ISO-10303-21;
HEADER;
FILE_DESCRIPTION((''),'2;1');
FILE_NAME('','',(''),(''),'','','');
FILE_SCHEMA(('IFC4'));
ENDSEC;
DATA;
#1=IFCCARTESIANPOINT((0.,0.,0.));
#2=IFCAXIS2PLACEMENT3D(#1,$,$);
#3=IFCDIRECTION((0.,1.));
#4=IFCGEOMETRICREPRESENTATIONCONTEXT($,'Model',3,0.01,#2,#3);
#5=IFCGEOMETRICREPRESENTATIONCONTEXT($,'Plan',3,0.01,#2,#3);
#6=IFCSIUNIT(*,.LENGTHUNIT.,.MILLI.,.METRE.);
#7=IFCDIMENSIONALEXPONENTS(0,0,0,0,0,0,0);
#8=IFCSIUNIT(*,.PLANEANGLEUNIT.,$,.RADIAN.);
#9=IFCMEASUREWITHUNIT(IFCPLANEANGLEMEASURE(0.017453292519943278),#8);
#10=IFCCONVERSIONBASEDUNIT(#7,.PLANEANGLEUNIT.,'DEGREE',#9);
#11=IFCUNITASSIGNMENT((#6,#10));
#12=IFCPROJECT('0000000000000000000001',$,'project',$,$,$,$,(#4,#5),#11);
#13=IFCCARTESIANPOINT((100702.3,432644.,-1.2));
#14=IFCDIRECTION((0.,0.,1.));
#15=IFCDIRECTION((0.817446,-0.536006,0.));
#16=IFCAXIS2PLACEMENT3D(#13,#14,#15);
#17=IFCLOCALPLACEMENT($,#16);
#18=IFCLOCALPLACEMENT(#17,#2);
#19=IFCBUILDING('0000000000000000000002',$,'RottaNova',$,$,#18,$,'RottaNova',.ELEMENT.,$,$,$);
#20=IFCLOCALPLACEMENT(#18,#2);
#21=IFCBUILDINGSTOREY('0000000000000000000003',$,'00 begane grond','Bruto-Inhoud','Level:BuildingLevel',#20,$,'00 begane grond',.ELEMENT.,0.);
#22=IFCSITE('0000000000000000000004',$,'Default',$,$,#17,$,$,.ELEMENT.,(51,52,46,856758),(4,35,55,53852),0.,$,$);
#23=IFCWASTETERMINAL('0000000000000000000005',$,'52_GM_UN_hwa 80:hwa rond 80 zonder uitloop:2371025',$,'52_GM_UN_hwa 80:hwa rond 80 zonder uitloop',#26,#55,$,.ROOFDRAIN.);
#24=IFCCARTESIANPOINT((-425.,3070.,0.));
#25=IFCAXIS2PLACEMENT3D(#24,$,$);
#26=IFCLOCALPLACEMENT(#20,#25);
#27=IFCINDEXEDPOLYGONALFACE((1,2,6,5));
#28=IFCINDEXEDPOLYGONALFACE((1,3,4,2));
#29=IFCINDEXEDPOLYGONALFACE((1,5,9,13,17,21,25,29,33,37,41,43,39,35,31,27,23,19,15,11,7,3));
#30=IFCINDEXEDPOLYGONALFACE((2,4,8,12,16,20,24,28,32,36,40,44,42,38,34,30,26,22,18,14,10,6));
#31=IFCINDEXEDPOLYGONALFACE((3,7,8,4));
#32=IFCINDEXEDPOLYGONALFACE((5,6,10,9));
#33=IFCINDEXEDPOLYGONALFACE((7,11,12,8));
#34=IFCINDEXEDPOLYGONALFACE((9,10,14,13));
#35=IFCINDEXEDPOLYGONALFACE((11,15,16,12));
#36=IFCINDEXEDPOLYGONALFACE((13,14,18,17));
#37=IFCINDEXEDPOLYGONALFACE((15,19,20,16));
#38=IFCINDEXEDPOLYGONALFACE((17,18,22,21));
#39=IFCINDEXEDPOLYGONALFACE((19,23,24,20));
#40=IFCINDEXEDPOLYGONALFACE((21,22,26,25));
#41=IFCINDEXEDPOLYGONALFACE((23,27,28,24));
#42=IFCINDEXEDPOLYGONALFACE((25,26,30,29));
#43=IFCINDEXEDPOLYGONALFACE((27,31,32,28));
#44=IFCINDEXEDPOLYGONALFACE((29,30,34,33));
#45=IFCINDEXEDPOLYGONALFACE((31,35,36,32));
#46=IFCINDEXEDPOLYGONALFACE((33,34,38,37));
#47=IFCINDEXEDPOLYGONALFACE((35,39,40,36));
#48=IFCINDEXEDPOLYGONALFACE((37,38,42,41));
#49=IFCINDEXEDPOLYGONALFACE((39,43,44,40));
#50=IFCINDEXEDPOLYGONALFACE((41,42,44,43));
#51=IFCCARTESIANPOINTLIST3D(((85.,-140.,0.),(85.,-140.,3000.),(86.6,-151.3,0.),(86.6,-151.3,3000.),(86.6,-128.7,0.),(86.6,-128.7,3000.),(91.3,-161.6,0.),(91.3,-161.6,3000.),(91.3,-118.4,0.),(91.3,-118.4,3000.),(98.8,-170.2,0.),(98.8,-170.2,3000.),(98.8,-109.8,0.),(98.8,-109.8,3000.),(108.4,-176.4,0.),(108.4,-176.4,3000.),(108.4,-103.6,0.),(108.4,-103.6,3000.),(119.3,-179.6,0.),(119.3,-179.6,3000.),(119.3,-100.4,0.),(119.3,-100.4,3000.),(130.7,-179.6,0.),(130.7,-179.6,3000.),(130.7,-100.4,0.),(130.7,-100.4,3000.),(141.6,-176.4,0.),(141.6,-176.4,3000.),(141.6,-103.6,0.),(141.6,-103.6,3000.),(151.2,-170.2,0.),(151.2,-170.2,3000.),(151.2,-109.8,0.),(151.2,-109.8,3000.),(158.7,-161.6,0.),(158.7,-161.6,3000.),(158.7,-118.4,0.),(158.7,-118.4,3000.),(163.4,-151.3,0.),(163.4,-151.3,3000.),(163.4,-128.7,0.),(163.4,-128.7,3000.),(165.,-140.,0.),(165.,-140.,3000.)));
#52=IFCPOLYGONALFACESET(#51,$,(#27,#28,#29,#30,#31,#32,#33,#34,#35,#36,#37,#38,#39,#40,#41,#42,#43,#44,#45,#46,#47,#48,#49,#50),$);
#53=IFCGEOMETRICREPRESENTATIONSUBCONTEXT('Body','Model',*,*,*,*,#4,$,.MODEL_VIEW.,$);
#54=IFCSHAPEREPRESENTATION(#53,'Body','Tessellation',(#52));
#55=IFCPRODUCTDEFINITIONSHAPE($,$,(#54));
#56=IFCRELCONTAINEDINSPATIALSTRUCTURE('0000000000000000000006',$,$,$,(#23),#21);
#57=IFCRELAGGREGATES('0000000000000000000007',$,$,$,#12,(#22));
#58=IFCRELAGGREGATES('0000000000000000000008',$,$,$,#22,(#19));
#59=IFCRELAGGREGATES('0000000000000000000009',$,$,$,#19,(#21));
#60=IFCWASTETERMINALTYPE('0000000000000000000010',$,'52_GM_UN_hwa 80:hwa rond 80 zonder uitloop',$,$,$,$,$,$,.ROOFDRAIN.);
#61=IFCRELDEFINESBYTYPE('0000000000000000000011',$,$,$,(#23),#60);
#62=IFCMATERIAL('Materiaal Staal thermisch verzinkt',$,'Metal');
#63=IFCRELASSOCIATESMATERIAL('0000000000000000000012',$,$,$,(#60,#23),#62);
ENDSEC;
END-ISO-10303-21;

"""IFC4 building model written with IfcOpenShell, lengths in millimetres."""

from ifc_helpers import new_model, entity, si_unit, converted_unit, direction, frame, origin, place, context, subcontext, project, spatial, arc, indexed_curve, outline, extrude, source, transform, mapped, material, type_object, type_shapes, element, save


model = new_model("IFC4")

# Units and contexts
model_context = context("Model", 3, precision=0.01, world=origin(), true_north=direction((0.0, 1.0)))
plan_context = context("Plan", 3, precision=0.01, world=origin(), true_north=direction((0.0, 1.0)))
body_context = subcontext(model_context, "Body", "Model", "MODEL_VIEW")
ifc_project = project(units=[si_unit("LENGTHUNIT", "METRE", prefix="MILLI"), converted_unit("PLANEANGLEUNIT", "DEGREE", entity("IfcPlaneAngleMeasure", 0.017453292519943278), si_unit("PLANEANGLEUNIT", "RADIAN"), dimensions=[0, 0, 0, 0, 0, 0, 0])], contexts=[model_context, plan_context])

# Site, building, storey
site_placement = place(None, frame((100702.3, 432644.0, -1.2), z_axis=(0.0, 0.0, 1.0), x_axis=(0.817446, -0.536006, 0.0)))
site = spatial("IfcSite", under=ifc_project, at=site_placement, Name="Default", CompositionType="ELEMENT", RefLatitude=(51, 52, 46, 856758), RefLongitude=(4, 35, 55, 53852), RefElevation=0.0)
building_placement = place(site_placement, origin())
building = spatial("IfcBuilding", under=site, at=building_placement, Name="RottaNova", LongName="RottaNova", CompositionType="ELEMENT")
storey_placement = place(building_placement, origin())
storey = spatial("IfcBuildingStorey", under=building, at=storey_placement, Name="00 begane grond", Description="Bruto-Inhoud", ObjectType="Level:BuildingLevel", LongName="00 begane grond", CompositionType="ELEMENT", Elevation=0.0)

# Waste terminal
ifc_material_1 = material(Name="Materiaal Staal thermisch verzinkt", Category="Metal")
waste_terminal_type = type_object("IfcWasteTerminalType", Name="52_GM_UN_hwa 80:hwa rond 80 zonder uitloop", PredefinedType="ROOFDRAIN", material=ifc_material_1)
shared_shape_1 = source(origin(), body_context, "Body", "SweptSolid", [
    extrude(outline(indexed_curve([(-40.0, 0.0), (0.0, -40.0), (40.0, 0.0), (0.0, 40.0)], segments=[arc(1, 2, 3), arc(3, 4, 1)], self_intersect=False)), frame((125.0, -140.0, 0.0)), (0.0, 0.0, 1.0), 3000.0),
])
type_shapes(waste_terminal_type, [shared_shape_1])
waste_terminal_placement = place(storey_placement, frame((-425.0, 3070.0, 0.0)))
element("IfcWasteTerminal", 1, at=waste_terminal_placement, inside=storey, type_object=waste_terminal_type, material=ifc_material_1, Name="52_GM_UN_hwa 80:hwa rond 80 zonder uitloop:2371025", ObjectType="52_GM_UN_hwa 80:hwa rond 80 zonder uitloop", PredefinedType="ROOFDRAIN", context=body_context, shape_type="MappedRepresentation", body=[
    mapped(shared_shape_1, transform((0.0, 0.0, 0.0), scale=1.0)),
])

save(model, "model.ifc")
